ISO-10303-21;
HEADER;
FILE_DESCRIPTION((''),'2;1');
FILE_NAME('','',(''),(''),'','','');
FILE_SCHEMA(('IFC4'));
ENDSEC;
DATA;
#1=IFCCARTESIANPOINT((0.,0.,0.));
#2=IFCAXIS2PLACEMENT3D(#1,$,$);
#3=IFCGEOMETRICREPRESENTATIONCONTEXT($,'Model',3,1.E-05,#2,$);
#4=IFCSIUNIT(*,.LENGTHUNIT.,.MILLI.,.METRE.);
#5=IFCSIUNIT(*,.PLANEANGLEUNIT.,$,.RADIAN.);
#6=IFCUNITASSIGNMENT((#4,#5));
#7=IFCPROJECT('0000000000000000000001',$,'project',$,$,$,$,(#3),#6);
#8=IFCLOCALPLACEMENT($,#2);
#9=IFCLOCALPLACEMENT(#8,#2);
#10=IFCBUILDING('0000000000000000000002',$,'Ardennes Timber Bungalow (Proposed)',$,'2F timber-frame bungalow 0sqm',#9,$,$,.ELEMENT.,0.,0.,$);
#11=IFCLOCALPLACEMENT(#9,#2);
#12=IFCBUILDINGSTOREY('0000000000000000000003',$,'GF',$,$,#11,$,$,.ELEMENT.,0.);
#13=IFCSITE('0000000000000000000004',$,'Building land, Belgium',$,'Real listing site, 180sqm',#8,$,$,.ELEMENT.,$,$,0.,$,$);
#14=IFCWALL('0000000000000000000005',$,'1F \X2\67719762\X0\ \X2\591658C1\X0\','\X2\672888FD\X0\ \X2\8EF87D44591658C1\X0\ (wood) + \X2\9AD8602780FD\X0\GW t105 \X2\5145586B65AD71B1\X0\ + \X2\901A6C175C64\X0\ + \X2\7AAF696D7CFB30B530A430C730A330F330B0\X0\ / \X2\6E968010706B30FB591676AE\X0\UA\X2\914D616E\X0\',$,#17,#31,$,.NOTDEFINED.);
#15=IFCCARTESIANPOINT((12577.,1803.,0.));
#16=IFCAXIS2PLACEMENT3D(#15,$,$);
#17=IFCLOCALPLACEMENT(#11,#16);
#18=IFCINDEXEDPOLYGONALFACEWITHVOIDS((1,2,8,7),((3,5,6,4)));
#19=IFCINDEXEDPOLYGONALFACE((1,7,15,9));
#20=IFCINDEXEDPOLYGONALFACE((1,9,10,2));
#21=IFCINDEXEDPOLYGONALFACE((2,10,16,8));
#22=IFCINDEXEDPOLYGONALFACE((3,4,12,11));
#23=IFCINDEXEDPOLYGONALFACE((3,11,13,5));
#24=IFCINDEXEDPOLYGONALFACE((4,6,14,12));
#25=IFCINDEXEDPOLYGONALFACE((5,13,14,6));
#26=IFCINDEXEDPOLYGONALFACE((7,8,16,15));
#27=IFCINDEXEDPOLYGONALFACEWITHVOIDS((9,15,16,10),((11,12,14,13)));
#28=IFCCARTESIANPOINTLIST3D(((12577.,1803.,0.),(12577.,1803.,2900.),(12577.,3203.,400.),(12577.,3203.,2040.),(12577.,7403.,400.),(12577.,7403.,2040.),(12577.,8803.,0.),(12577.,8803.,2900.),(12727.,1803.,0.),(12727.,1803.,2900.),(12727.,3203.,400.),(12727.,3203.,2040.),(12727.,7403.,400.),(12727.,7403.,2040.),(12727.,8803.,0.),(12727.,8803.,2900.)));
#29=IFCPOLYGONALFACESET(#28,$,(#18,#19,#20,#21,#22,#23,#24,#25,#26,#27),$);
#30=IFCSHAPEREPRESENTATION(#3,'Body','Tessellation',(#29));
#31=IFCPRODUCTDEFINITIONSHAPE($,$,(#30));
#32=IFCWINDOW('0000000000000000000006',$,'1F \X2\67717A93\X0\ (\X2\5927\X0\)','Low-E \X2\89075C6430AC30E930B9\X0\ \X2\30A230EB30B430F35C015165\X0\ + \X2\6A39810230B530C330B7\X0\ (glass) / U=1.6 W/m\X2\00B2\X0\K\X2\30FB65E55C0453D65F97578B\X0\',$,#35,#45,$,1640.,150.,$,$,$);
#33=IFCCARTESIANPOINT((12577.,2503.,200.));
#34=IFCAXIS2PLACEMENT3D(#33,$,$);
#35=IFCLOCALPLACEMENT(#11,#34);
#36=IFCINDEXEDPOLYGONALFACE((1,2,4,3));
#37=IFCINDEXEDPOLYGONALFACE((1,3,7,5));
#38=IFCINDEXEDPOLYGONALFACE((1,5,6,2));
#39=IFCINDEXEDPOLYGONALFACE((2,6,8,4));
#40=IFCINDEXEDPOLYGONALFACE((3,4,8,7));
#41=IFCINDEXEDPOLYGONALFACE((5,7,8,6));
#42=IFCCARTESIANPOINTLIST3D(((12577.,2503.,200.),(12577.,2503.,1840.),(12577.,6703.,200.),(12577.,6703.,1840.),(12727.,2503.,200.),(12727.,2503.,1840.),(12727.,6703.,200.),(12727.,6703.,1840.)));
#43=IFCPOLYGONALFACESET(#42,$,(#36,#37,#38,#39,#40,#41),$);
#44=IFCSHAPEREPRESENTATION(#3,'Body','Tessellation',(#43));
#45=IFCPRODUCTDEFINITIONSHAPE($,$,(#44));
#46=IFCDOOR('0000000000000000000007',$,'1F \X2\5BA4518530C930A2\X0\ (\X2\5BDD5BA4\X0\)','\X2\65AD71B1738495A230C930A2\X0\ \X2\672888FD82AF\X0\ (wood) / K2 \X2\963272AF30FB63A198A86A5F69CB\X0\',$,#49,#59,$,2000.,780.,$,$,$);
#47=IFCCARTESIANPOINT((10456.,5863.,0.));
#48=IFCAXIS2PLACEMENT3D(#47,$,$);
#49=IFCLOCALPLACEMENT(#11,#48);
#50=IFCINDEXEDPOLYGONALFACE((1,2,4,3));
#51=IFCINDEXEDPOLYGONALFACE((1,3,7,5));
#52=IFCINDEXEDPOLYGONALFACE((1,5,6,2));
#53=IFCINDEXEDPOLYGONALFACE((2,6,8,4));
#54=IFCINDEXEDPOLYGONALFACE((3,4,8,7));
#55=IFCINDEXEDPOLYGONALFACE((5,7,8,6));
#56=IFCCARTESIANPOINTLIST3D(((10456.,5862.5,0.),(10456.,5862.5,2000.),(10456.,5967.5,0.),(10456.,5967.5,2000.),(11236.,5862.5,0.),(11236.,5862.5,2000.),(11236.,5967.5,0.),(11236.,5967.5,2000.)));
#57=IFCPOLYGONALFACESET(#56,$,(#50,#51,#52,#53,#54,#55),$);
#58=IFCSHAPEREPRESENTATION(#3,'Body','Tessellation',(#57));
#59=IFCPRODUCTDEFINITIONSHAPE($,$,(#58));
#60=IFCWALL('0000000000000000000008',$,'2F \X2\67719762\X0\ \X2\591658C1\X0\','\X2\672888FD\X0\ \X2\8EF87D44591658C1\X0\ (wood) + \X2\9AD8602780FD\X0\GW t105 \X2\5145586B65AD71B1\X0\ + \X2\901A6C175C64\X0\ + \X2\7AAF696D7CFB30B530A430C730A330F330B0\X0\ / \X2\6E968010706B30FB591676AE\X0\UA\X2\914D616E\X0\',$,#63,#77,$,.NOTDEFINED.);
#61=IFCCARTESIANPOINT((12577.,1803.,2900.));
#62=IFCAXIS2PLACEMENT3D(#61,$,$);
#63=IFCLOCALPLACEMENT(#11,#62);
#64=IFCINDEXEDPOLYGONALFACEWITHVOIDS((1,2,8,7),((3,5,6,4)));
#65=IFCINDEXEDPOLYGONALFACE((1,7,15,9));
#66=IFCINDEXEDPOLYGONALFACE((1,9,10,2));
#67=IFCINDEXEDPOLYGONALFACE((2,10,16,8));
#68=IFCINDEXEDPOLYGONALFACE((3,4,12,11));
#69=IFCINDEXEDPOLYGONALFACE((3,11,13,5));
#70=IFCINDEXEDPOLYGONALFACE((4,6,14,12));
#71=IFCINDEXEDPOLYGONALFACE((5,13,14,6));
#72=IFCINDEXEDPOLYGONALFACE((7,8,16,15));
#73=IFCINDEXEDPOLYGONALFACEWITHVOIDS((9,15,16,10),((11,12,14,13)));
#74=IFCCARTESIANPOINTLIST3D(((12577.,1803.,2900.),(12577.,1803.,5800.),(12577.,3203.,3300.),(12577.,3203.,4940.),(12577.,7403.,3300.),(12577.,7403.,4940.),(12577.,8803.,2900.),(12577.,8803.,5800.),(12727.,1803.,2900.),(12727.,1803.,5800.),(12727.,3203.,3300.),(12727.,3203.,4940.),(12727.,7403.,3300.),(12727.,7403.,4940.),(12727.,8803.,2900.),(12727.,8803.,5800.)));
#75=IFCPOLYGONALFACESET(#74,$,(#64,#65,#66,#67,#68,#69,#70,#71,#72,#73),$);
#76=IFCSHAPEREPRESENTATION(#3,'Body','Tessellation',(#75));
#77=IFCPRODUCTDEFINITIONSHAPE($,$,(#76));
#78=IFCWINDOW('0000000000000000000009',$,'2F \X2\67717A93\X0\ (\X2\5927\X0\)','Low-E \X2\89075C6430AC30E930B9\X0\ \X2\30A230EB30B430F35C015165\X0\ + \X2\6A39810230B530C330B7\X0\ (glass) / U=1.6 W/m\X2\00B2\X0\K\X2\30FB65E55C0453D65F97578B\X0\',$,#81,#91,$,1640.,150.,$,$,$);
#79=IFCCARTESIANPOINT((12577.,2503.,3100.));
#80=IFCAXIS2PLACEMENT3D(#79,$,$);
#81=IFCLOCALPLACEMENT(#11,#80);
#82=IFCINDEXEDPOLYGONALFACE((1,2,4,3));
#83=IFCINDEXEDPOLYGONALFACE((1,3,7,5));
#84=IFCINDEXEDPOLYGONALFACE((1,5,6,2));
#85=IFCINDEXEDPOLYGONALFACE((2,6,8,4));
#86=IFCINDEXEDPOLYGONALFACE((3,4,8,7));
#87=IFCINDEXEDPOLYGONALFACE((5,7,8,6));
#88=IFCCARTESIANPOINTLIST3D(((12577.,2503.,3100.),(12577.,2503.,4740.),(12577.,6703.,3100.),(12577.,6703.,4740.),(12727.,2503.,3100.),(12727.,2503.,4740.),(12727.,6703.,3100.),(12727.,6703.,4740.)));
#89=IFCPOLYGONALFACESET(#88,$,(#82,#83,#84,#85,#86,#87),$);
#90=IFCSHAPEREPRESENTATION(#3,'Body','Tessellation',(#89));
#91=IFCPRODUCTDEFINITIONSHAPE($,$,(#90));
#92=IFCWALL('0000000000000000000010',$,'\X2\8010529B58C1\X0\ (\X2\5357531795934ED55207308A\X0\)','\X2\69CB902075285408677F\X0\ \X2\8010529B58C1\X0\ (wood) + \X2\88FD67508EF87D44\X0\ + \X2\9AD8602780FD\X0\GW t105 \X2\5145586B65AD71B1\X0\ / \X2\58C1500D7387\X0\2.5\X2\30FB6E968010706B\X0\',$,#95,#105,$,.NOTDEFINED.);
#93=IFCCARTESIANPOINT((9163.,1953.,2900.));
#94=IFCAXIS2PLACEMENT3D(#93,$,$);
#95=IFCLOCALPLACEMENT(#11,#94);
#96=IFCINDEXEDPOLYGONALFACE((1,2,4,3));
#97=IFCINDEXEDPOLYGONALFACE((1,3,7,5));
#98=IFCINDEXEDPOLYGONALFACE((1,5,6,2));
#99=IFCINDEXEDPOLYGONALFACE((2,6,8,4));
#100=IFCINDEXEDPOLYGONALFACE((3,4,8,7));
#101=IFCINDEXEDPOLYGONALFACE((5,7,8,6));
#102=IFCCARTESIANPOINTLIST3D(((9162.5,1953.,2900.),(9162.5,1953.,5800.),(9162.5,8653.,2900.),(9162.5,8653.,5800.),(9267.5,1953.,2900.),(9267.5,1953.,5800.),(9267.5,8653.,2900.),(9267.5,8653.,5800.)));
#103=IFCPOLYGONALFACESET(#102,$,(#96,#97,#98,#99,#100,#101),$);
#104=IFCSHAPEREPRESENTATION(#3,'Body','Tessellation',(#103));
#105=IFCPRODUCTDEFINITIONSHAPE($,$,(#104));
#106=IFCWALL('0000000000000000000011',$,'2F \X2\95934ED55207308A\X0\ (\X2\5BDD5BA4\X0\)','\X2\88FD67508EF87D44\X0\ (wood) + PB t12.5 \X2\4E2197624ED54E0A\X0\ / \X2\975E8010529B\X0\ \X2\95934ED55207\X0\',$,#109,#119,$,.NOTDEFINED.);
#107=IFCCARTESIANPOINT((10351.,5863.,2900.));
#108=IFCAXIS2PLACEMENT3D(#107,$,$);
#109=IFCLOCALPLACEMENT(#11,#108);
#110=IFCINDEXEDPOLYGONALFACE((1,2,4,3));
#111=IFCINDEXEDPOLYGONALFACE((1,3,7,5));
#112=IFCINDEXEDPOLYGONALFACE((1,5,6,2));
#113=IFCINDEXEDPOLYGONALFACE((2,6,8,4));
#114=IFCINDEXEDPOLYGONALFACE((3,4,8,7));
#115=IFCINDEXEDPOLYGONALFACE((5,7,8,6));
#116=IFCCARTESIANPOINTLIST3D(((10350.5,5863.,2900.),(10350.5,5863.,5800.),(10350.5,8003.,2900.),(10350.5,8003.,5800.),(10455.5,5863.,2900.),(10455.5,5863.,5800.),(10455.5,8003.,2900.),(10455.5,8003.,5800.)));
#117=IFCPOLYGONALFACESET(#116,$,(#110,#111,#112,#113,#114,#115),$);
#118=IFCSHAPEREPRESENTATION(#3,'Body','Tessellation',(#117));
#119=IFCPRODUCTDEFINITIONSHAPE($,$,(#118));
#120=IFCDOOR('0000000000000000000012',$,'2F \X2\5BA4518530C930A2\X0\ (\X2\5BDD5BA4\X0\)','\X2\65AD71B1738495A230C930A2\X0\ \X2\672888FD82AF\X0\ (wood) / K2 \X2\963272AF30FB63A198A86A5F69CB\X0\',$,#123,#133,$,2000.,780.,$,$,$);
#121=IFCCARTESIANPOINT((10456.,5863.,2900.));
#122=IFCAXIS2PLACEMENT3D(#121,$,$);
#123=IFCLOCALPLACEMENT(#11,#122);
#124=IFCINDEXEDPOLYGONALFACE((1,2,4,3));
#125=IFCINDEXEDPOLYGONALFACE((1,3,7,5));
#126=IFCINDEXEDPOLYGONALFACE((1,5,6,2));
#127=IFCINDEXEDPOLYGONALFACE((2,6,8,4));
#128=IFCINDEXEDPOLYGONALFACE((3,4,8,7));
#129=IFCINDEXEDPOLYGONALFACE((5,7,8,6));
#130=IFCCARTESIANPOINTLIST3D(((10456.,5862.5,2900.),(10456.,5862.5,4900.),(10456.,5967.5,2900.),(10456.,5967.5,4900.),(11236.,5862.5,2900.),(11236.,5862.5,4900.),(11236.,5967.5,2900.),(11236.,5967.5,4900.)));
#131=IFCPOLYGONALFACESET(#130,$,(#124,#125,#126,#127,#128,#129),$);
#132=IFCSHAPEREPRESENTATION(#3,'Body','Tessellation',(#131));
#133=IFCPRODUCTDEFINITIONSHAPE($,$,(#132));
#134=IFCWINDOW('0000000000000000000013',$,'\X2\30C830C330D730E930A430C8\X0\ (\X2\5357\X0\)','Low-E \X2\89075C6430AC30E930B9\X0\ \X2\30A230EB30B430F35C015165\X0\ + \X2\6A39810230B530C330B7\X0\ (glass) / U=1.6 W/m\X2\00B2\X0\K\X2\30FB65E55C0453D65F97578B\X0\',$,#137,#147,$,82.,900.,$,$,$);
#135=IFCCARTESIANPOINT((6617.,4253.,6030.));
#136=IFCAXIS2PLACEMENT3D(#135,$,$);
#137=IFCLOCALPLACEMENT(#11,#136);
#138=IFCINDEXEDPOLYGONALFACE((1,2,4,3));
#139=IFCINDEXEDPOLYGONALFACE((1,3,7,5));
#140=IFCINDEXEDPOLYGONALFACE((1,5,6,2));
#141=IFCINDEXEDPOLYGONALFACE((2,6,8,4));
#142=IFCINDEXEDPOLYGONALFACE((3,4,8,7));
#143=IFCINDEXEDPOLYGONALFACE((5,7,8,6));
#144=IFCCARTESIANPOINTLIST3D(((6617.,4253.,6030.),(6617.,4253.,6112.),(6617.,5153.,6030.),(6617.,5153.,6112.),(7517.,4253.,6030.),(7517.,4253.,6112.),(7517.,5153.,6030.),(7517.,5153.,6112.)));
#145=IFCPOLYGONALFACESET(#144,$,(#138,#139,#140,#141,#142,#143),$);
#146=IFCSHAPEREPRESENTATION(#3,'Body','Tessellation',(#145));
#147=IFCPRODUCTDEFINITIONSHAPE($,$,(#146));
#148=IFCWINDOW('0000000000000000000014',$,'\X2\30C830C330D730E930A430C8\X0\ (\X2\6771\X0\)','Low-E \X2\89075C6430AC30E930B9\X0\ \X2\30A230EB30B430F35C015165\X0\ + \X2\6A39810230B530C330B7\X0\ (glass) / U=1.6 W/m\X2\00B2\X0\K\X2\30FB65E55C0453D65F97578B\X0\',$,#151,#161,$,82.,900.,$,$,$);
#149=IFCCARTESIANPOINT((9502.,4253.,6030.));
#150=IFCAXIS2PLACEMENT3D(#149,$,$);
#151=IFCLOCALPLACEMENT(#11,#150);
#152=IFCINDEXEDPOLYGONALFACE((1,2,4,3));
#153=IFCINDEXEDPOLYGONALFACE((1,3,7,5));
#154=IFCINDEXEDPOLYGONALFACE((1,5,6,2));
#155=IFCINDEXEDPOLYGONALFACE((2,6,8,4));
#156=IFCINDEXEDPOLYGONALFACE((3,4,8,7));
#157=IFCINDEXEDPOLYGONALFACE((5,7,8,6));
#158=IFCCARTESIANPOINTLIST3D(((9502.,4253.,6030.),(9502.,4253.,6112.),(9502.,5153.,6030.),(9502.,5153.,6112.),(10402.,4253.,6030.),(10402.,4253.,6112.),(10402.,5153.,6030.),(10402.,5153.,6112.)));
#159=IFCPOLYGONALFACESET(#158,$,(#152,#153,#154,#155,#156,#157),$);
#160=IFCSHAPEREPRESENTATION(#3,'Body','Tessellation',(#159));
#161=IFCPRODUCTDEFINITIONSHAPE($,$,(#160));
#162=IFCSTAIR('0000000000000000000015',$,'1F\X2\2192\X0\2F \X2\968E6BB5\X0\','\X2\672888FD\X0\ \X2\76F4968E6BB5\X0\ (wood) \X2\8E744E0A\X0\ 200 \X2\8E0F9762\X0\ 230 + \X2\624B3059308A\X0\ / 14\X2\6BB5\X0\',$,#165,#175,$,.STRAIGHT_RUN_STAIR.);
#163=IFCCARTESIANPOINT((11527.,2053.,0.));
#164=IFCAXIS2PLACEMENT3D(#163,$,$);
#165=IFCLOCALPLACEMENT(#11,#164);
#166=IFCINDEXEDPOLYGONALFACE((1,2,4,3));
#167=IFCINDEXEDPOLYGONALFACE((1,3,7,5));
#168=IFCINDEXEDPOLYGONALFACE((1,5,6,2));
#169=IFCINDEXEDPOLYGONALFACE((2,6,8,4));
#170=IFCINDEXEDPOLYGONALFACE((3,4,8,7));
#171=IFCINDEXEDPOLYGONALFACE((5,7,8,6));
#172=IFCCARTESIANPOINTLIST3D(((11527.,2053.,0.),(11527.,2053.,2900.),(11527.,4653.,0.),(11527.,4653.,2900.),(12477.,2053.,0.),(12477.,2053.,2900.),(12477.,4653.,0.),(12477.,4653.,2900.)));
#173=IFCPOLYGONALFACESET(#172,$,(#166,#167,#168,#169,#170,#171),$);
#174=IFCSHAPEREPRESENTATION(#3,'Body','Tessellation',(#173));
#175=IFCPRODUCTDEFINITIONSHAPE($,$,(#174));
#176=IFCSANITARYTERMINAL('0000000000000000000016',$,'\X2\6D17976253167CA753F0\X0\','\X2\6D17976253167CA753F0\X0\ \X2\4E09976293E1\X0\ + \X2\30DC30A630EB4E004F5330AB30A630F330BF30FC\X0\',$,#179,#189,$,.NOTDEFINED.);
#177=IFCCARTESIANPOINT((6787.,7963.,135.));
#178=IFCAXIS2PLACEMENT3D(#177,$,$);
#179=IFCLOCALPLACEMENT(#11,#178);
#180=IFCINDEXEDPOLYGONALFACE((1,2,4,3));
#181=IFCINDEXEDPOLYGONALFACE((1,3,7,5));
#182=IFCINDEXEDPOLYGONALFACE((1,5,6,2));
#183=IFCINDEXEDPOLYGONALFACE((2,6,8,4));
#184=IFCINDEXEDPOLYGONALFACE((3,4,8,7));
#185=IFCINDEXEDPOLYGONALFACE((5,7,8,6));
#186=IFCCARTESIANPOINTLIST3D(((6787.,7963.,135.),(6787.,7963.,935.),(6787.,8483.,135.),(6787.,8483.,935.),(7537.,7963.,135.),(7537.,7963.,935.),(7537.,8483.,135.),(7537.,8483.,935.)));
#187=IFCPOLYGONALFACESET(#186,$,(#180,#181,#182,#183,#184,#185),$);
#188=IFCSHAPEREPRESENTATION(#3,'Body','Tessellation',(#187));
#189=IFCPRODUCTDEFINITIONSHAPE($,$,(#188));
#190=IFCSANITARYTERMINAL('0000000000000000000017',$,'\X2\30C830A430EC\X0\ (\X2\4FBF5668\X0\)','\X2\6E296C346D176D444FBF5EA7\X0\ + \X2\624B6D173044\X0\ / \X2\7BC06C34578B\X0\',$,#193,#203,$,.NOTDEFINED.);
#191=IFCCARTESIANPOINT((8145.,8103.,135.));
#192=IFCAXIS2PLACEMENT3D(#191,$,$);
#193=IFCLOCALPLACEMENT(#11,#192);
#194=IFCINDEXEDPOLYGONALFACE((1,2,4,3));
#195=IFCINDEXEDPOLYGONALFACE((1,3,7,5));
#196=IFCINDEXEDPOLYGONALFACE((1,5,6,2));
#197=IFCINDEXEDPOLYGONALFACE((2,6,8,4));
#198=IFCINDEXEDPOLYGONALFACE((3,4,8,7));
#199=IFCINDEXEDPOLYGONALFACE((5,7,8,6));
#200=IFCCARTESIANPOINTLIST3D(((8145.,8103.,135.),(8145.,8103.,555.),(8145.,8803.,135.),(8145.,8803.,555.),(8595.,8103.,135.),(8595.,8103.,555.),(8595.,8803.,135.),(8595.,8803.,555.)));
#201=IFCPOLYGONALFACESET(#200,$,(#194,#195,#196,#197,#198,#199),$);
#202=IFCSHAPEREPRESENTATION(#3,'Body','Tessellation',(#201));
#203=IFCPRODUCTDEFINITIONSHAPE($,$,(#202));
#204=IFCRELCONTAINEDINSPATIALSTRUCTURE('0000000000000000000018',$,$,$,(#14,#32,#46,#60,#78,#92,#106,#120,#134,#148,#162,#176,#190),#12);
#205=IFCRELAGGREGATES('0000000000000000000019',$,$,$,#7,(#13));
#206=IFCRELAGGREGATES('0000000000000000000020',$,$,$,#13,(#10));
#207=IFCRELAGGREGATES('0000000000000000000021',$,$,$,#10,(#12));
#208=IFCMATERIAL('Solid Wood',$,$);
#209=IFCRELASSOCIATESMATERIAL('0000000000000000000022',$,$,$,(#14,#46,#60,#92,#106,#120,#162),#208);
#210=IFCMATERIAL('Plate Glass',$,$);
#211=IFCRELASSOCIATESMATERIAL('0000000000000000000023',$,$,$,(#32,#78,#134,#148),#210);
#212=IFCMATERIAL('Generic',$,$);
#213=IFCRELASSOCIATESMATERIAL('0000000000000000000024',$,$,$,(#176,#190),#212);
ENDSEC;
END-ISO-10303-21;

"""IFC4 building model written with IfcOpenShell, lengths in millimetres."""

from ifc_helpers import new_model, si_unit, frame, frame_2d, origin, place, context, project, spatial, rectangle, extrude, material, element, fill, save


model = new_model("IFC4")

# Units and contexts
model_context = context("Model", 3, precision=1e-05, world=origin())
ifc_project = project(units=[si_unit("LENGTHUNIT", "METRE", prefix="MILLI"), si_unit("PLANEANGLEUNIT", "RADIAN")], contexts=[model_context])

# Site, building, storey
site_placement = place(None, origin())
site = spatial("IfcSite", under=ifc_project, at=site_placement, Name="Building land, Belgium", ObjectType="Real listing site, 180sqm", CompositionType="ELEMENT", RefElevation=0.0)
building_placement = place(site_placement, origin())
building = spatial("IfcBuilding", under=site, at=building_placement, Name="Ardennes Timber Bungalow (Proposed)", ObjectType="2F timber-frame bungalow 0sqm", CompositionType="ELEMENT", ElevationOfRefHeight=0.0, ElevationOfTerrain=0.0)
storey_placement = place(building_placement, origin())
storey = spatial("IfcBuildingStorey", under=building, at=storey_placement, Name="GF", CompositionType="ELEMENT", Elevation=0.0)

# Wall, opening, window
ifc_material_1 = material(Name="Solid Wood")
wall_1_placement = place(storey_placement, frame((12577.0, 1803.0, 0.0)))
wall_1 = element("IfcWall", 1, at=wall_1_placement, inside=storey, material=ifc_material_1, Name="1F 東面 外壁", Description="木製 軸組外壁 (wood) + 高性能GW t105 充填断熱 + 通気層 + 窯業系サイディング / 準耐火・外皮UA配慮", PredefinedType="NOTDEFINED", context=model_context, shape_type="SweptSolid", body=[
    extrude(rectangle(XDim=150.0, YDim=7000.0, at=frame_2d((75.0, 3500.0))), frame((12577.0, 1803.0, 0.0)), (0.0, 0.0, 1.0), 2900.0),
])
opening_1_placement = place(storey_placement, frame((12577.0, 2503.0, 200.0)))
opening_1 = element("IfcOpeningElement", 2, at=opening_1_placement, cuts=wall_1, PredefinedType="NOTDEFINED", context=model_context, shape_type="SweptSolid", body=[
    extrude(rectangle(XDim=150.0, YDim=4200.0, at=frame_2d((75.0, 2100.0))), frame((12577.0, 2503.0, 200.0)), (0.0, 0.0, 1.0), 1640.0),
])
ifc_material_2 = material(Name="Plate Glass")
window_1_placement = place(storey_placement, frame((12577.0, 2503.0, 200.0)))
window_1 = element("IfcWindow", 3, at=window_1_placement, inside=storey, material=ifc_material_2, Name="1F 東窓 (大)", Description="Low-E 複層ガラス アルゴン封入 + 樹脂サッシ (glass) / U=1.6 W/m²K・日射取得型", OverallHeight=1640.0, OverallWidth=150.0, context=model_context, shape_type="SweptSolid", body=[
    extrude(rectangle(XDim=150.0, YDim=4200.0, at=frame_2d((75.0, 2100.0))), frame((12577.0, 2503.0, 200.0)), (0.0, 0.0, 1.0), 1640.0),
])
fill(opening_1, window_1)

# Door
door_1_placement = place(storey_placement, frame((10456.0, 5863.0, 0.0)))
element("IfcDoor", 4, at=door_1_placement, inside=storey, material=ifc_material_1, Name="1F 室内ドア (寝室)", Description="断熱玄関ドア 木製芯 (wood) / K2 防犯・採風機構", OverallHeight=2000.0, OverallWidth=780.0, context=model_context, shape_type="SweptSolid", body=[
    extrude(rectangle(XDim=780.0, YDim=105.0, at=frame_2d((390.0, 52.0))), frame((10456.0, 5863.0, 0.0)), (0.0, 0.0, 1.0), 2000.0),
])

# Wall, opening, window
wall_2_placement = place(storey_placement, frame((12577.0, 1803.0, 2900.0)))
wall_2 = element("IfcWall", 5, at=wall_2_placement, inside=storey, material=ifc_material_1, Name="2F 東面 外壁", Description="木製 軸組外壁 (wood) + 高性能GW t105 充填断熱 + 通気層 + 窯業系サイディング / 準耐火・外皮UA配慮", PredefinedType="NOTDEFINED", context=model_context, shape_type="SweptSolid", body=[
    extrude(rectangle(XDim=150.0, YDim=7000.0, at=frame_2d((75.0, 3500.0))), frame((12577.0, 1803.0, 2900.0)), (0.0, 0.0, 1.0), 2900.0),
])
opening_2_placement = place(storey_placement, frame((12577.0, 2503.0, 3100.0)))
opening_2 = element("IfcOpeningElement", 6, at=opening_2_placement, cuts=wall_2, PredefinedType="NOTDEFINED", context=model_context, shape_type="SweptSolid", body=[
    extrude(rectangle(XDim=150.0, YDim=4200.0, at=frame_2d((75.0, 2100.0))), frame((12577.0, 2503.0, 3100.0)), (0.0, 0.0, 1.0), 1640.0),
])
window_2_placement = place(storey_placement, frame((12577.0, 2503.0, 3100.0)))
window_2 = element("IfcWindow", 7, at=window_2_placement, inside=storey, material=ifc_material_2, Name="2F 東窓 (大)", Description="Low-E 複層ガラス アルゴン封入 + 樹脂サッシ (glass) / U=1.6 W/m²K・日射取得型", OverallHeight=1640.0, OverallWidth=150.0, context=model_context, shape_type="SweptSolid", body=[
    extrude(rectangle(XDim=150.0, YDim=4200.0, at=frame_2d((75.0, 2100.0))), frame((12577.0, 2503.0, 3100.0)), (0.0, 0.0, 1.0), 1640.0),
])
fill(opening_2, window_2)

# Walls
wall_3_placement = place(storey_placement, frame((9163.0, 1953.0, 2900.0)))
element("IfcWall", 8, at=wall_3_placement, inside=storey, material=ifc_material_1, Name="耐力壁 (南北間仕切り)", Description="構造用合板 耐力壁 (wood) + 製材軸組 + 高性能GW t105 充填断熱 / 壁倍率2.5・準耐火", PredefinedType="NOTDEFINED", context=model_context, shape_type="SweptSolid", body=[
    extrude(rectangle(XDim=105.0, YDim=6700.0, at=frame_2d((52.0, 3350.0))), frame((9163.0, 1953.0, 2900.0)), (0.0, 0.0, 1.0), 2900.0),
])
wall_4_placement = place(storey_placement, frame((10351.0, 5863.0, 2900.0)))
element("IfcWall", 9, at=wall_4_placement, inside=storey, material=ifc_material_1, Name="2F 間仕切り (寝室)", Description="製材軸組 (wood) + PB t12.5 両面仕上 / 非耐力 間仕切", PredefinedType="NOTDEFINED", context=model_context, shape_type="SweptSolid", body=[
    extrude(rectangle(XDim=105.0, YDim=2140.0, at=frame_2d((52.0, 1070.0))), frame((10351.0, 5863.0, 2900.0)), (0.0, 0.0, 1.0), 2900.0),
])

# Door
door_2_placement = place(storey_placement, frame((10456.0, 5863.0, 2900.0)))
element("IfcDoor", 10, at=door_2_placement, inside=storey, material=ifc_material_1, Name="2F 室内ドア (寝室)", Description="断熱玄関ドア 木製芯 (wood) / K2 防犯・採風機構", OverallHeight=2000.0, OverallWidth=780.0, context=model_context, shape_type="SweptSolid", body=[
    extrude(rectangle(XDim=780.0, YDim=105.0, at=frame_2d((390.0, 52.0))), frame((10456.0, 5863.0, 2900.0)), (0.0, 0.0, 1.0), 2000.0),
])

# Windows
window_3_placement = place(storey_placement, frame((6617.0, 4253.0, 6030.0)))
element("IfcWindow", 11, at=window_3_placement, inside=storey, material=ifc_material_2, Name="トップライト (南)", Description="Low-E 複層ガラス アルゴン封入 + 樹脂サッシ (glass) / U=1.6 W/m²K・日射取得型", OverallHeight=82.0, OverallWidth=900.0, context=model_context, shape_type="SweptSolid", body=[
    extrude(rectangle(XDim=900.0, YDim=900.0, at=frame_2d((450.0, 450.0))), frame((6617.0, 4253.0, 6030.0)), (0.0, 0.0, 1.0), 82.0),
])
window_4_placement = place(storey_placement, frame((9502.0, 4253.0, 6030.0)))
element("IfcWindow", 12, at=window_4_placement, inside=storey, material=ifc_material_2, Name="トップライト (東)", Description="Low-E 複層ガラス アルゴン封入 + 樹脂サッシ (glass) / U=1.6 W/m²K・日射取得型", OverallHeight=82.0, OverallWidth=900.0, context=model_context, shape_type="SweptSolid", body=[
    extrude(rectangle(XDim=900.0, YDim=900.0, at=frame_2d((450.0, 450.0))), frame((9502.0, 4253.0, 6030.0)), (0.0, 0.0, 1.0), 82.0),
])

# Stair
stair_placement = place(storey_placement, frame((11527.0, 2053.0, 0.0)))
element("IfcStair", 13, at=stair_placement, inside=storey, material=ifc_material_1, Name="1F→2F 階段", Description="木製 直階段 (wood) 蹴上 200 踏面 230 + 手すり / 14段", PredefinedType="STRAIGHT_RUN_STAIR", context=model_context, shape_type="SweptSolid", body=[
    extrude(rectangle(XDim=950.0, YDim=2600.0, at=frame_2d((475.0, 1300.0))), frame((11527.0, 2053.0, 0.0)), (0.0, 0.0, 1.0), 2900.0),
])

# Sanitary terminals
ifc_material_3 = material(Name="Generic")
sanitary_terminal_1_placement = place(storey_placement, frame((6787.0, 7963.0, 135.0)))
element("IfcSanitaryTerminal", 14, at=sanitary_terminal_1_placement, inside=storey, material=ifc_material_3, Name="洗面化粧台", Description="洗面化粧台 三面鏡 + ボウル一体カウンター", PredefinedType="NOTDEFINED", context=model_context, shape_type="SweptSolid", body=[
    extrude(rectangle(XDim=750.0, YDim=520.0, at=frame_2d((375.0, 260.0))), frame((6787.0, 7963.0, 135.0)), (0.0, 0.0, 1.0), 800.0),
])
sanitary_terminal_2_placement = place(storey_placement, frame((8145.0, 8103.0, 135.0)))
element("IfcSanitaryTerminal", 15, at=sanitary_terminal_2_placement, inside=storey, material=ifc_material_3, Name="トイレ (便器)", Description="温水洗浄便座 + 手洗い / 節水型", PredefinedType="NOTDEFINED", context=model_context, shape_type="SweptSolid", body=[
    extrude(rectangle(XDim=450.0, YDim=700.0, at=frame_2d((225.0, 350.0))), frame((8145.0, 8103.0, 135.0)), (0.0, 0.0, 1.0), 420.0),
])

save(model, "model.ifc")
